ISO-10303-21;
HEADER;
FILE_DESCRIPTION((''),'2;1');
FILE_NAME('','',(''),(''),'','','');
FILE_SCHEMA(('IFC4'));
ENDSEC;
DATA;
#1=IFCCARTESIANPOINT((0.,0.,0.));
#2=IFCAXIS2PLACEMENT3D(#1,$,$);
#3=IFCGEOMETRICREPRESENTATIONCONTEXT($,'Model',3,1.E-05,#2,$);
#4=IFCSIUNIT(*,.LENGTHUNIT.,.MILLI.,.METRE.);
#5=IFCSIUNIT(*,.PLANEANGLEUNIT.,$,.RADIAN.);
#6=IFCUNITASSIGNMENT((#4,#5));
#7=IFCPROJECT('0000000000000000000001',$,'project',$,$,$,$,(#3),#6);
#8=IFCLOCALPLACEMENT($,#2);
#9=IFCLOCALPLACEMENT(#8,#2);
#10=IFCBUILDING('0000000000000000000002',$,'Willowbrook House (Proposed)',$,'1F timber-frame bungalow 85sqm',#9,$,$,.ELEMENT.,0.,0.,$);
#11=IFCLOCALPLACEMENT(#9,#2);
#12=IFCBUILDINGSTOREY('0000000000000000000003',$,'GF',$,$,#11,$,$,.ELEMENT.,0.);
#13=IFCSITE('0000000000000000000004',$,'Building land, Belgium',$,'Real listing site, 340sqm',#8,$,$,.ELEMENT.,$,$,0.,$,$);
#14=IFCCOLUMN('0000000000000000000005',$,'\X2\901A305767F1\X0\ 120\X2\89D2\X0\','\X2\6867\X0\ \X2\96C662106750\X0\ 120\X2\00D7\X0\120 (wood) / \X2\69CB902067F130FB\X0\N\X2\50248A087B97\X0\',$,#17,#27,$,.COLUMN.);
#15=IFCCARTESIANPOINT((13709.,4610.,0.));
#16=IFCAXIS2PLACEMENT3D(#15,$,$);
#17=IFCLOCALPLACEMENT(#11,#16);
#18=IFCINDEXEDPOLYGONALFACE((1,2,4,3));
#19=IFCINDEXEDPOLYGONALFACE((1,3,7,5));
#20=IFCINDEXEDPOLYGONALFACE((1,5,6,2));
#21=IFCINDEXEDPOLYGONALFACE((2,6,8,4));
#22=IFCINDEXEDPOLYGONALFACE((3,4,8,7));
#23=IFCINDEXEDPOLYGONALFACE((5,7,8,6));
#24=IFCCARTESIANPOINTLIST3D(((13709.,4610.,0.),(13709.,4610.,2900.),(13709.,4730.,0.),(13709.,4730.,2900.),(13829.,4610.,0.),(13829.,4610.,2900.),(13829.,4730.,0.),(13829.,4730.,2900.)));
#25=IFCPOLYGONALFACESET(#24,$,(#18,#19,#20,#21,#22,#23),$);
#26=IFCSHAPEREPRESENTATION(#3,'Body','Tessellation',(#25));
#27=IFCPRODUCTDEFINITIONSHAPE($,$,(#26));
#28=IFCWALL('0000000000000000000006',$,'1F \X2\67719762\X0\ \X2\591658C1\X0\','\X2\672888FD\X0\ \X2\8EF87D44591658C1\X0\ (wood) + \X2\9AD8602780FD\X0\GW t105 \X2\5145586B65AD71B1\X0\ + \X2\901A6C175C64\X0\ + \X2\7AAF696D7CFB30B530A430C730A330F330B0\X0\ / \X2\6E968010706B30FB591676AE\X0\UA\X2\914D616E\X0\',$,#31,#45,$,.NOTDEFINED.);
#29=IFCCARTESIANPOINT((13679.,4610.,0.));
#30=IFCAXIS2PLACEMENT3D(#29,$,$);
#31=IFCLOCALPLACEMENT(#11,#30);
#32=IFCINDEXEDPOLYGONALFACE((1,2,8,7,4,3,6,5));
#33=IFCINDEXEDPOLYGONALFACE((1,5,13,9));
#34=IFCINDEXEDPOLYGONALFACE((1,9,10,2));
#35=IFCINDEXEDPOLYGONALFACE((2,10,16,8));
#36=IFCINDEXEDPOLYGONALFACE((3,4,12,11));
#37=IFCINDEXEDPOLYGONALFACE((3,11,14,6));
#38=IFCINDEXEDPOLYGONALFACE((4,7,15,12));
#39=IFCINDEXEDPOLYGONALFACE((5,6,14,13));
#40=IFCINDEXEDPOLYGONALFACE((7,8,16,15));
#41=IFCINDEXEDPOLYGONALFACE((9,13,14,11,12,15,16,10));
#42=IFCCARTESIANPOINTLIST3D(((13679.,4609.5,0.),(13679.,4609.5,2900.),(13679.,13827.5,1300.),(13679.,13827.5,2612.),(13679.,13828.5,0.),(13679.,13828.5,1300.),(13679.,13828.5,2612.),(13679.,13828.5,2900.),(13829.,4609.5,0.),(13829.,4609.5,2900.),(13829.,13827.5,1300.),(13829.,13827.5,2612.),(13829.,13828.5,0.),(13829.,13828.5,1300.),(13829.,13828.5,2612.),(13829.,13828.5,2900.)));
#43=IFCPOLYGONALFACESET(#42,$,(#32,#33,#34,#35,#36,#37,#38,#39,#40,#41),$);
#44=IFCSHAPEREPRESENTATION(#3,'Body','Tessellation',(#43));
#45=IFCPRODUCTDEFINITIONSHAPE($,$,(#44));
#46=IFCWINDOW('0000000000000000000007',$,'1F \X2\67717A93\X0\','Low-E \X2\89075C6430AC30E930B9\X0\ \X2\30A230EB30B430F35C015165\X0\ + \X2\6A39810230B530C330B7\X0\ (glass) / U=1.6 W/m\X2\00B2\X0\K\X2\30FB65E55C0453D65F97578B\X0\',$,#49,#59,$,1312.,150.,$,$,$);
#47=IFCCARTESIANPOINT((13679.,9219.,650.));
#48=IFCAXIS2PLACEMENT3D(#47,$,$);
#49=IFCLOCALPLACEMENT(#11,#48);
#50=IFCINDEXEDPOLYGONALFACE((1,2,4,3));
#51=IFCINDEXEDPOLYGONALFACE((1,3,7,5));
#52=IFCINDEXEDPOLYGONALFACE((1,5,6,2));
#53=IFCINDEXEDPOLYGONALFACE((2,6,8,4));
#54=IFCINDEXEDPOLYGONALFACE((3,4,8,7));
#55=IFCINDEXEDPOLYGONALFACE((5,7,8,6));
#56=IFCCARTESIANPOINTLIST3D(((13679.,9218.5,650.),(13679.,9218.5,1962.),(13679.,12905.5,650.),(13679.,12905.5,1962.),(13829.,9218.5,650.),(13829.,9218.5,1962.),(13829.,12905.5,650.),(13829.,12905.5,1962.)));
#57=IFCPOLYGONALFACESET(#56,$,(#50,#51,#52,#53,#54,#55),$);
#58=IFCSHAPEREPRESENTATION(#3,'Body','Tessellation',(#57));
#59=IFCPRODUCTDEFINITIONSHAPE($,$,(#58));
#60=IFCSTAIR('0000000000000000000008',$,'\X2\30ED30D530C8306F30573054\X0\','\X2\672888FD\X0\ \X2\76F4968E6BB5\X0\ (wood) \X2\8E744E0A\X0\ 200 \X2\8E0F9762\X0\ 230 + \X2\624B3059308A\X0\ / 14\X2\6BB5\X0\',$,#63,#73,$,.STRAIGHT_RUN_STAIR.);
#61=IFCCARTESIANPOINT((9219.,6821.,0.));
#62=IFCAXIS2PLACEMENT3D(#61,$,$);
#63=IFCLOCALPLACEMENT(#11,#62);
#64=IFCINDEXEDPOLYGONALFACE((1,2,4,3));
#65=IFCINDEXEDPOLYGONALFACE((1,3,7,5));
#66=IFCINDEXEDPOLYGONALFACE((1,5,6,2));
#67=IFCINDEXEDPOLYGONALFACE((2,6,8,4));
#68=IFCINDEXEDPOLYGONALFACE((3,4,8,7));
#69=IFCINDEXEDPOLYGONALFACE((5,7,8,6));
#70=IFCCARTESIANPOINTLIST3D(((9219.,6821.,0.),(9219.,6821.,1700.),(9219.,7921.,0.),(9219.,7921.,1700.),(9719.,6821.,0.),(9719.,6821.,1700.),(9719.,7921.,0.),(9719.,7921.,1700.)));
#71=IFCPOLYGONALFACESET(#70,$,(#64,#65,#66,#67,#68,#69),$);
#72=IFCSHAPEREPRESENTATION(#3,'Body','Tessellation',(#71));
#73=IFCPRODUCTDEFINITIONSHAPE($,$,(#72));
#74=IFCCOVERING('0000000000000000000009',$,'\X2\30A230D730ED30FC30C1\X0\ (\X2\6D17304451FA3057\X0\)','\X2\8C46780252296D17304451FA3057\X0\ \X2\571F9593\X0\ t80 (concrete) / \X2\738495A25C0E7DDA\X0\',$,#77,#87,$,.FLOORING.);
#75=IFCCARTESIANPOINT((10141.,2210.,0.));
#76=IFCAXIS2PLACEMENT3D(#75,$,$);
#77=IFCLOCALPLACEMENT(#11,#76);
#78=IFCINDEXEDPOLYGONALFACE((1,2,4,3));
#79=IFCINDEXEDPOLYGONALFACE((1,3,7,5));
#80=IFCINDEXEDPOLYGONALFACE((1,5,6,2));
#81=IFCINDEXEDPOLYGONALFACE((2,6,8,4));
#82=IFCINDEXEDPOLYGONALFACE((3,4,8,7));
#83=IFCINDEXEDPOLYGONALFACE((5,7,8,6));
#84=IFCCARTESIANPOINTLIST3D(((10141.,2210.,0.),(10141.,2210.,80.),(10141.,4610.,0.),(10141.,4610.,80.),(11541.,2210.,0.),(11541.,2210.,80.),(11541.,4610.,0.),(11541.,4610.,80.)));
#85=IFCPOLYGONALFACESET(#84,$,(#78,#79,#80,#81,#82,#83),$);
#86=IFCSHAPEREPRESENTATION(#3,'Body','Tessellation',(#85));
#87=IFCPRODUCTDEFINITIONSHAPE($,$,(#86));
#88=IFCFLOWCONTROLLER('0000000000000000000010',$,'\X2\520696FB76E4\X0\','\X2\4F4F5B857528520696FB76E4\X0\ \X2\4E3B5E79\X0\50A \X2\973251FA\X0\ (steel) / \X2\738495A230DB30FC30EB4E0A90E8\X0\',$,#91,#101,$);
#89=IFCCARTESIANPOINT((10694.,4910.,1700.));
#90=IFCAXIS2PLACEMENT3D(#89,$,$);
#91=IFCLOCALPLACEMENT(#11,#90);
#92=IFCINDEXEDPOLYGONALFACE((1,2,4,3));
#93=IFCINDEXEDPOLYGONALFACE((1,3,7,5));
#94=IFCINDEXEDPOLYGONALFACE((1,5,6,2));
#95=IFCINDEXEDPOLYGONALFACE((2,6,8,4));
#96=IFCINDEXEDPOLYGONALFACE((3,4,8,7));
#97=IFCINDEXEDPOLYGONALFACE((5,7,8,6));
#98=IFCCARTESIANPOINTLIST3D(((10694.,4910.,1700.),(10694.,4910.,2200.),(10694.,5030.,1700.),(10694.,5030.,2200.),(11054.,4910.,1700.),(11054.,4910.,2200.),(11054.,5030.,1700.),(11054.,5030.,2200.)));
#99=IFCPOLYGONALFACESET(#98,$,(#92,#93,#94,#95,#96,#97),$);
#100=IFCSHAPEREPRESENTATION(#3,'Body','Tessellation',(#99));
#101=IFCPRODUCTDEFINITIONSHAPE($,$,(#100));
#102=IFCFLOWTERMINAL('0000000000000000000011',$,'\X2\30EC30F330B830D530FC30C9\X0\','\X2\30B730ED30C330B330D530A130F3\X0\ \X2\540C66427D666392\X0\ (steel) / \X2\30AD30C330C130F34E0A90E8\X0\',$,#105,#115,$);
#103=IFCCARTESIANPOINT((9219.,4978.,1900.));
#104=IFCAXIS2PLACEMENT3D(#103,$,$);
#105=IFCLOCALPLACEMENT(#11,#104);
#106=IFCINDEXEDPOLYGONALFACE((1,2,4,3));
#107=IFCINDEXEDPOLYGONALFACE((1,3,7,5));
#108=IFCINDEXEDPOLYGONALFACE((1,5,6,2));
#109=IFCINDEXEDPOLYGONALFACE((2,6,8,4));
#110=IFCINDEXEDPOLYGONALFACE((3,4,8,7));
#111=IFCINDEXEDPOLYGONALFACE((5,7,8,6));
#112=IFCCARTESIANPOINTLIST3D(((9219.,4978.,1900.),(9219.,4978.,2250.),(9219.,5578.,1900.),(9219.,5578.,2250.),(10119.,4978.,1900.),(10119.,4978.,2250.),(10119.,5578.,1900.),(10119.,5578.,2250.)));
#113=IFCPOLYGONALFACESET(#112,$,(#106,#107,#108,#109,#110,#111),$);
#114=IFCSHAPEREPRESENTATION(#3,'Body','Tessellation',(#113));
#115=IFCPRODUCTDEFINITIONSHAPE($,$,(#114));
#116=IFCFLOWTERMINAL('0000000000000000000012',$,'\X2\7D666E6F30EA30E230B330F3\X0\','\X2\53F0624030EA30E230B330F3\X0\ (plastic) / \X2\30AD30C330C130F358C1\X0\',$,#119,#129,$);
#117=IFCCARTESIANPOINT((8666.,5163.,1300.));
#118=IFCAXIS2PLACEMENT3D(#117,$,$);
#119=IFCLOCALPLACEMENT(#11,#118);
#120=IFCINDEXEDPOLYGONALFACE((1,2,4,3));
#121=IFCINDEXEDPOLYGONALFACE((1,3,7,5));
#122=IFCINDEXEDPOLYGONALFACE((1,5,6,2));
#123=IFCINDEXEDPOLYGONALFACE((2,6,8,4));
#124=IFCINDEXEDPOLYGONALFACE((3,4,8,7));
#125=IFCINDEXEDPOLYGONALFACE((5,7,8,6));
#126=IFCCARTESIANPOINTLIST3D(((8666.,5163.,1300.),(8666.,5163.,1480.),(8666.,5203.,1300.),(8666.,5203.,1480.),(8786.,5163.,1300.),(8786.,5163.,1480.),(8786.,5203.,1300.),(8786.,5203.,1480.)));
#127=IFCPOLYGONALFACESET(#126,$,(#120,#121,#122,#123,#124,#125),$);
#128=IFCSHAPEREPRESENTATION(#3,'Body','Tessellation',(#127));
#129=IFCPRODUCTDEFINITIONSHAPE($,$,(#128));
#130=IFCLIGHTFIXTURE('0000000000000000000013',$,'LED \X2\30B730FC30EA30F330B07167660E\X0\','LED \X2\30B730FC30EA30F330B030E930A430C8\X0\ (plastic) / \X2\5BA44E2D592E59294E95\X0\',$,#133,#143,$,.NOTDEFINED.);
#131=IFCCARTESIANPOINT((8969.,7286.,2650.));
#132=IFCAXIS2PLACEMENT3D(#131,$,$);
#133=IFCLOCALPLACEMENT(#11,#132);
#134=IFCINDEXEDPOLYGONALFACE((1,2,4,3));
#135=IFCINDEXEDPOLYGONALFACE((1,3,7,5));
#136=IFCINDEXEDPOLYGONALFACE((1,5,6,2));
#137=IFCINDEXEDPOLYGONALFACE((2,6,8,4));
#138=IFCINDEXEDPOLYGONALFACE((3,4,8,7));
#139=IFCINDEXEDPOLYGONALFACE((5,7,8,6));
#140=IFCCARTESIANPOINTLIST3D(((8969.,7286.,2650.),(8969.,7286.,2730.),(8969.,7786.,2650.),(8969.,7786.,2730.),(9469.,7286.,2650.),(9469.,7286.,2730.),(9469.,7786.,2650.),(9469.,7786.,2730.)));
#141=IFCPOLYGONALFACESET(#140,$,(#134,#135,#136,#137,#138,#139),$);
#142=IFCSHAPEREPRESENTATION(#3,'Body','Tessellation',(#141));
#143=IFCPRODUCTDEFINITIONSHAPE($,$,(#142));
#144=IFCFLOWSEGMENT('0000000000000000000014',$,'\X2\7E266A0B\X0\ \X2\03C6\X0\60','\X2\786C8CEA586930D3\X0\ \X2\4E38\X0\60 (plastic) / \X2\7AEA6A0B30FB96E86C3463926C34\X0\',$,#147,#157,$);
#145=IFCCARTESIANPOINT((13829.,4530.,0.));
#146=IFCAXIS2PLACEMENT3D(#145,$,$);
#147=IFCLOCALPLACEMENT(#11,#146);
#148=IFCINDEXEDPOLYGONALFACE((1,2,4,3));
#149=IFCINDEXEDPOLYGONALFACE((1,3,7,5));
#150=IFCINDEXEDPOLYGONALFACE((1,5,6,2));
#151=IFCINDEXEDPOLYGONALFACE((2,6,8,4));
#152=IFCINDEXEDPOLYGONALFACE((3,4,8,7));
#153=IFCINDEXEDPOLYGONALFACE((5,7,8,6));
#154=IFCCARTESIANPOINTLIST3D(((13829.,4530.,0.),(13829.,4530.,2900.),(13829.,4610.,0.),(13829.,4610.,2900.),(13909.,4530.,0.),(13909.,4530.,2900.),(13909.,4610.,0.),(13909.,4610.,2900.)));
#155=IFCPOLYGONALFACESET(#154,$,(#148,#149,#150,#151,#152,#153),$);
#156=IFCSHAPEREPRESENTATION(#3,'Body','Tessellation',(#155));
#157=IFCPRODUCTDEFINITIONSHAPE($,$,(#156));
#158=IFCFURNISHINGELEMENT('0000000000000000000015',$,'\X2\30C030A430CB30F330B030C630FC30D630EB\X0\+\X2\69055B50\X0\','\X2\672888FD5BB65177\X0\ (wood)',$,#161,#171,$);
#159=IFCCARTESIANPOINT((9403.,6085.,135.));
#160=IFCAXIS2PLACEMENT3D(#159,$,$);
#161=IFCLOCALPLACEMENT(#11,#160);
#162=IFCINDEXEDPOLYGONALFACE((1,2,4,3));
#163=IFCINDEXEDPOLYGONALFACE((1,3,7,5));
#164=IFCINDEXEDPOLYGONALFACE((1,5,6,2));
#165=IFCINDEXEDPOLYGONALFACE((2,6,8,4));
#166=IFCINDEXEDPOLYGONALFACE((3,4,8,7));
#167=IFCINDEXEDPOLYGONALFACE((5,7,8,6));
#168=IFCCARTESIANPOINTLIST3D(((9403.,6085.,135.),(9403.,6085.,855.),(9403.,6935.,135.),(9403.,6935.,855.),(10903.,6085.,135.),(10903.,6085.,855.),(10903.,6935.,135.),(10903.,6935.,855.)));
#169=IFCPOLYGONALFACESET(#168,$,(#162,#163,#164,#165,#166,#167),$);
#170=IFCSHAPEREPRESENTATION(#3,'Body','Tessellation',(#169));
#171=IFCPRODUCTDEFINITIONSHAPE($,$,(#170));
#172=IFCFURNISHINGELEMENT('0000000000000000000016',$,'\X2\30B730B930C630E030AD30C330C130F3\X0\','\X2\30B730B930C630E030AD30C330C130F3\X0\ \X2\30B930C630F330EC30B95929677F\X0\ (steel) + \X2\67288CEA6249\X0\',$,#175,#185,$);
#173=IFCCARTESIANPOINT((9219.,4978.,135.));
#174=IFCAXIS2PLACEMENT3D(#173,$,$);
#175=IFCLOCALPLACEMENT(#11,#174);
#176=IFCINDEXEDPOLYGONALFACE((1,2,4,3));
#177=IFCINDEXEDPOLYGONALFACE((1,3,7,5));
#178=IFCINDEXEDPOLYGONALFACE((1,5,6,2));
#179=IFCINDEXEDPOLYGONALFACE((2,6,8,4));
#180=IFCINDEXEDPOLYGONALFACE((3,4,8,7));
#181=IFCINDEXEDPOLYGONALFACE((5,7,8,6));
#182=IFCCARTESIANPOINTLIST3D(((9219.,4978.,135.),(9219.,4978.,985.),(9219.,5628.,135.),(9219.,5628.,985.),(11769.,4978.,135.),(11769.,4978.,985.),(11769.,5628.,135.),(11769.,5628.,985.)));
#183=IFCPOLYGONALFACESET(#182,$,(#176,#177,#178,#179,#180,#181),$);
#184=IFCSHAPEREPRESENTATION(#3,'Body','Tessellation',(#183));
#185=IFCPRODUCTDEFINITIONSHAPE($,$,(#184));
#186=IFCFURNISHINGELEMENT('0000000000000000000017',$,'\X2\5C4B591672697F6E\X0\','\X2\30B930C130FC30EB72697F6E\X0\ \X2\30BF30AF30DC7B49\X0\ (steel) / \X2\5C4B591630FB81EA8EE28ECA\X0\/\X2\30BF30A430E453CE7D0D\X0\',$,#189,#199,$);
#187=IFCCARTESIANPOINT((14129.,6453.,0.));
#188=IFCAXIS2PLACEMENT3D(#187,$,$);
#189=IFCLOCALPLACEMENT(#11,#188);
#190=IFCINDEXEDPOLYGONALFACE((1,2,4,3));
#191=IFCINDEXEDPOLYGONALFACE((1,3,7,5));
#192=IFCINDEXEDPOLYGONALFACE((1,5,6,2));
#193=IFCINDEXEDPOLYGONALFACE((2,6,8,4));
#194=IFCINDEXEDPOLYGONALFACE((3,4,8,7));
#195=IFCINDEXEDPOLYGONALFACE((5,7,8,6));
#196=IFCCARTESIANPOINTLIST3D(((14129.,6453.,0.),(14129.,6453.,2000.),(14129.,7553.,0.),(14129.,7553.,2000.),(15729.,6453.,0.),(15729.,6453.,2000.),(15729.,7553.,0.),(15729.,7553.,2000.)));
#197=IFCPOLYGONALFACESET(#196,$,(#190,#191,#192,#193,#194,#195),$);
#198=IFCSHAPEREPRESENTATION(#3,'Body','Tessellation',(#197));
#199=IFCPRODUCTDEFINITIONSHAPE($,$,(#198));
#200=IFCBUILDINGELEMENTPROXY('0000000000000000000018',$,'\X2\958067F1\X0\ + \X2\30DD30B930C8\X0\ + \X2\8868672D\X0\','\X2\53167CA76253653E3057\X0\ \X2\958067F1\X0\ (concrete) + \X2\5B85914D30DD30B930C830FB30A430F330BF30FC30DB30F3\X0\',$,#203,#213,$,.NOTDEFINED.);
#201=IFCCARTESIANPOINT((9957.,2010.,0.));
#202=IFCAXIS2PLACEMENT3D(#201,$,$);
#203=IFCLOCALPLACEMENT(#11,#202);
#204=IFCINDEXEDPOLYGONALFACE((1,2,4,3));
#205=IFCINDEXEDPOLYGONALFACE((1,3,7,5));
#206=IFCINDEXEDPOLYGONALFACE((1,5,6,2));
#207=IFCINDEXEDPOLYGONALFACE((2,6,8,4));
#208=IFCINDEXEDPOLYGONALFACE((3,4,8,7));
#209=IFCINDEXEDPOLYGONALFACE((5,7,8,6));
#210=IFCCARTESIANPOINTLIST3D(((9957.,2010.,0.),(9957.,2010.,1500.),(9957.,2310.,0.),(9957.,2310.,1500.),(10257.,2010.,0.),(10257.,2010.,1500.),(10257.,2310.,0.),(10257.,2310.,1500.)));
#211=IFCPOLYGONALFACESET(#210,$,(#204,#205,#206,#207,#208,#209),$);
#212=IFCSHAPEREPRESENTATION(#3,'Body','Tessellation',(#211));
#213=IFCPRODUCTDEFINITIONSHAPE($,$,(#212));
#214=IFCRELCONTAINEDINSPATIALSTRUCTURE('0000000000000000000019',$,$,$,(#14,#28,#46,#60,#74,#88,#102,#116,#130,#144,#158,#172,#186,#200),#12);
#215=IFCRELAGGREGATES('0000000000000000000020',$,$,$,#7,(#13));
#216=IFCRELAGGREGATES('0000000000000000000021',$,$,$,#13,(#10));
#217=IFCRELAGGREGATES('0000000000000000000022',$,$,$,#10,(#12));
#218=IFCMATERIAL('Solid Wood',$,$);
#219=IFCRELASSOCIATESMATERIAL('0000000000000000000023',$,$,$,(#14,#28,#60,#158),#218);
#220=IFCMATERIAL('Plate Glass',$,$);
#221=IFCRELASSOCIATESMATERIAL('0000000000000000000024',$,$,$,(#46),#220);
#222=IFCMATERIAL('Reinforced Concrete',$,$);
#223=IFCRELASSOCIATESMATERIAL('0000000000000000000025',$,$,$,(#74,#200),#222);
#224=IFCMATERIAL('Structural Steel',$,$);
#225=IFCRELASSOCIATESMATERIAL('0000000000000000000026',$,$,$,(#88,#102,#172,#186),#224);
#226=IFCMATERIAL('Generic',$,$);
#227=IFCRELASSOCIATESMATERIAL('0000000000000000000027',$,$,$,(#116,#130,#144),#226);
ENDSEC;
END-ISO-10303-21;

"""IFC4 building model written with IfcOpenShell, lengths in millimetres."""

from ifc_helpers import new_model, si_unit, frame, frame_2d, origin, place, context, project, spatial, rectangle, extrude, material, element, fill, save


model = new_model("IFC4")

# Units and contexts
model_context = context("Model", 3, precision=1e-05, world=origin())
ifc_project = project(units=[si_unit("LENGTHUNIT", "METRE", prefix="MILLI"), si_unit("PLANEANGLEUNIT", "RADIAN")], contexts=[model_context])

# Site, building, storey
site_placement = place(None, origin())
site = spatial("IfcSite", under=ifc_project, at=site_placement, Name="Building land, Belgium", ObjectType="Real listing site, 340sqm", CompositionType="ELEMENT", RefElevation=0.0)
building_placement = place(site_placement, origin())
building = spatial("IfcBuilding", under=site, at=building_placement, Name="Willowbrook House (Proposed)", ObjectType="1F timber-frame bungalow 85sqm", CompositionType="ELEMENT", ElevationOfRefHeight=0.0, ElevationOfTerrain=0.0)
storey_placement = place(building_placement, origin())
storey = spatial("IfcBuildingStorey", under=building, at=storey_placement, Name="GF", CompositionType="ELEMENT", Elevation=0.0)

# Column
ifc_material_1 = material(Name="Solid Wood")
column_1_placement = place(storey_placement, frame((13709.0, 4610.0, 0.0)))
element("IfcColumn", 1, at=column_1_placement, inside=storey, material=ifc_material_1, Name="通し柱 120角", Description="桧 集成材 120×120 (wood) / 構造柱・N値計算", PredefinedType="COLUMN", context=model_context, shape_type="SweptSolid", body=[
    extrude(rectangle(XDim=120.0, YDim=120.0, at=frame_2d((60.0, 60.0))), frame((13709.0, 4610.0, 0.0)), (0.0, 0.0, 1.0), 2900.0),
])

# Wall, opening, window
wall_1_placement = place(storey_placement, frame((13679.0, 4610.0, 0.0)))
wall_1 = element("IfcWall", 2, at=wall_1_placement, inside=storey, material=ifc_material_1, Name="1F 東面 外壁", Description="木製 軸組外壁 (wood) + 高性能GW t105 充填断熱 + 通気層 + 窯業系サイディング / 準耐火・外皮UA配慮", PredefinedType="NOTDEFINED", context=model_context, shape_type="SweptSolid", body=[
    extrude(rectangle(XDim=150.0, YDim=9219.0, at=frame_2d((75.0, 4609.0))), frame((13679.0, 4610.0, 0.0)), (0.0, 0.0, 1.0), 2900.0),
])
opening_placement = place(storey_placement, frame((13679.0, 9219.0, 650.0)))
opening = element("IfcOpeningElement", 3, at=opening_placement, cuts=wall_1, PredefinedType="NOTDEFINED", context=model_context, shape_type="SweptSolid", body=[
    extrude(rectangle(XDim=150.0, YDim=3687.0, at=frame_2d((75.0, 1843.0))), frame((13679.0, 9219.0, 650.0)), (0.0, 0.0, 1.0), 1312.0),
])
ifc_material_2 = material(Name="Plate Glass")
window_placement = place(storey_placement, frame((13679.0, 9219.0, 650.0)))
window = element("IfcWindow", 4, at=window_placement, inside=storey, material=ifc_material_2, Name="1F 東窓", Description="Low-E 複層ガラス アルゴン封入 + 樹脂サッシ (glass) / U=1.6 W/m²K・日射取得型", OverallHeight=1312.0, OverallWidth=150.0, context=model_context, shape_type="SweptSolid", body=[
    extrude(rectangle(XDim=150.0, YDim=3687.0, at=frame_2d((75.0, 1843.0))), frame((13679.0, 9219.0, 650.0)), (0.0, 0.0, 1.0), 1312.0),
])
fill(opening, window)

# Stair
stair_placement = place(storey_placement, frame((9219.0, 6821.0, 0.0)))
element("IfcStair", 5, at=stair_placement, inside=storey, material=ifc_material_1, Name="ロフトはしご", Description="木製 直階段 (wood) 蹴上 200 踏面 230 + 手すり / 14段", PredefinedType="STRAIGHT_RUN_STAIR", context=model_context, shape_type="SweptSolid", body=[
    extrude(rectangle(XDim=500.0, YDim=1100.0, at=frame_2d((250.0, 550.0))), frame((9219.0, 6821.0, 0.0)), (0.0, 0.0, 1.0), 1700.0),
])

# Covering
ifc_material_3 = material(Name="Reinforced Concrete")
covering_placement = place(storey_placement, frame((10141.0, 2210.0, 0.0)))
element("IfcCovering", 6, at=covering_placement, inside=storey, material=ifc_material_3, Name="アプローチ (洗い出し)", Description="豆砂利洗い出し 土間 t80 (concrete) / 玄関導線", PredefinedType="FLOORING", context=model_context, shape_type="SweptSolid", body=[
    extrude(rectangle(XDim=1400.0, YDim=2400.0, at=frame_2d((700.0, 1200.0))), frame((10141.0, 2210.0, 0.0)), (0.0, 0.0, 1.0), 80.0),
])

# Flow controller
ifc_material_4 = material(Name="Structural Steel")
flow_controller_placement = place(storey_placement, frame((10694.0, 4910.0, 1700.0)))
element("IfcFlowController", 7, at=flow_controller_placement, inside=storey, material=ifc_material_4, Name="分電盤", Description="住宅用分電盤 主幹50A 露出 (steel) / 玄関ホール上部", context=model_context, shape_type="SweptSolid", body=[
    extrude(rectangle(XDim=360.0, YDim=120.0, at=frame_2d((180.0, 60.0))), frame((10694.0, 4910.0, 1700.0)), (0.0, 0.0, 1.0), 500.0),
])

# Flow terminals
flow_terminal_1_placement = place(storey_placement, frame((9219.0, 4978.0, 1900.0)))
element("IfcFlowTerminal", 8, at=flow_terminal_1_placement, inside=storey, material=ifc_material_4, Name="レンジフード", Description="シロッコファン 同時給排 (steel) / キッチン上部", context=model_context, shape_type="SweptSolid", body=[
    extrude(rectangle(XDim=900.0, YDim=600.0, at=frame_2d((450.0, 300.0))), frame((9219.0, 4978.0, 1900.0)), (0.0, 0.0, 1.0), 350.0),
])
ifc_material_5 = material(Name="Generic")
flow_terminal_2_placement = place(storey_placement, frame((8666.0, 5163.0, 1300.0)))
element("IfcFlowTerminal", 9, at=flow_terminal_2_placement, inside=storey, material=ifc_material_5, Name="給湯リモコン", Description="台所リモコン (plastic) / キッチン壁", context=model_context, shape_type="SweptSolid", body=[
    extrude(rectangle(XDim=120.0, YDim=40.0, at=frame_2d((60.0, 20.0))), frame((8666.0, 5163.0, 1300.0)), (0.0, 0.0, 1.0), 180.0),
])

# Light fixture
light_fixture_placement = place(storey_placement, frame((8969.0, 7286.0, 2650.0)))
element("IfcLightFixture", 10, at=light_fixture_placement, inside=storey, material=ifc_material_5, Name="LED シーリング照明", Description="LED シーリングライト (plastic) / 室中央天井", PredefinedType="NOTDEFINED", context=model_context, shape_type="SweptSolid", body=[
    extrude(rectangle(XDim=500.0, YDim=500.0, at=frame_2d((250.0, 250.0))), frame((8969.0, 7286.0, 2650.0)), (0.0, 0.0, 1.0), 80.0),
])

# Flow segment
flow_segment_placement = place(storey_placement, frame((13829.0, 4530.0, 0.0)))
element("IfcFlowSegment", 11, at=flow_segment_placement, inside=storey, material=ifc_material_5, Name="縦樋 φ60", Description="硬質塩ビ 丸60 (plastic) / 竪樋・雨水排水", context=model_context, shape_type="SweptSolid", body=[
    extrude(rectangle(XDim=80.0, YDim=80.0, at=frame_2d((40.0, 40.0))), frame((13829.0, 4530.0, 0.0)), (0.0, 0.0, 1.0), 2900.0),
])

# Furnishing elements
furnishing_1_placement = place(storey_placement, frame((9403.0, 6085.0, 135.0)))
element("IfcFurnishingElement", 12, at=furnishing_1_placement, inside=storey, material=ifc_material_1, Name="ダイニングテーブル+椅子", Description="木製家具 (wood)", context=model_context, shape_type="SweptSolid", body=[
    extrude(rectangle(XDim=1500.0, YDim=850.0, at=frame_2d((750.0, 425.0))), frame((9403.0, 6085.0, 135.0)), (0.0, 0.0, 1.0), 720.0),
])
furnishing_2_placement = place(storey_placement, frame((9219.0, 4978.0, 135.0)))
element("IfcFurnishingElement", 13, at=furnishing_2_placement, inside=storey, material=ifc_material_4, Name="システムキッチン", Description="システムキッチン ステンレス天板 (steel) + 木質扉", context=model_context, shape_type="SweptSolid", body=[
    extrude(rectangle(XDim=2550.0, YDim=650.0, at=frame_2d((1275.0, 325.0))), frame((9219.0, 4978.0, 135.0)), (0.0, 0.0, 1.0), 850.0),
])
furnishing_3_placement = place(storey_placement, frame((14129.0, 6453.0, 0.0)))
element("IfcFurnishingElement", 14, at=furnishing_3_placement, inside=storey, material=ifc_material_4, Name="屋外物置", Description="スチール物置 タクボ等 (steel) / 屋外・自転車/タイヤ収納", context=model_context, shape_type="SweptSolid", body=[
    extrude(rectangle(XDim=1600.0, YDim=1100.0, at=frame_2d((800.0, 550.0))), frame((14129.0, 6453.0, 0.0)), (0.0, 0.0, 1.0), 2000.0),
])

# Building element proxy
proxy_placement = place(storey_placement, frame((9957.0, 2010.0, 0.0)))
element("IfcBuildingElementProxy", 15, at=proxy_placement, inside=storey, material=ifc_material_3, Name="門柱 + ポスト + 表札", Description="化粧打放し 門柱 (concrete) + 宅配ポスト・インターホン", PredefinedType="NOTDEFINED", context=model_context, shape_type="SweptSolid", body=[
    extrude(rectangle(XDim=300.0, YDim=300.0, at=frame_2d((150.0, 150.0))), frame((9957.0, 2010.0, 0.0)), (0.0, 0.0, 1.0), 1500.0),
])

save(model, "model.ifc")
